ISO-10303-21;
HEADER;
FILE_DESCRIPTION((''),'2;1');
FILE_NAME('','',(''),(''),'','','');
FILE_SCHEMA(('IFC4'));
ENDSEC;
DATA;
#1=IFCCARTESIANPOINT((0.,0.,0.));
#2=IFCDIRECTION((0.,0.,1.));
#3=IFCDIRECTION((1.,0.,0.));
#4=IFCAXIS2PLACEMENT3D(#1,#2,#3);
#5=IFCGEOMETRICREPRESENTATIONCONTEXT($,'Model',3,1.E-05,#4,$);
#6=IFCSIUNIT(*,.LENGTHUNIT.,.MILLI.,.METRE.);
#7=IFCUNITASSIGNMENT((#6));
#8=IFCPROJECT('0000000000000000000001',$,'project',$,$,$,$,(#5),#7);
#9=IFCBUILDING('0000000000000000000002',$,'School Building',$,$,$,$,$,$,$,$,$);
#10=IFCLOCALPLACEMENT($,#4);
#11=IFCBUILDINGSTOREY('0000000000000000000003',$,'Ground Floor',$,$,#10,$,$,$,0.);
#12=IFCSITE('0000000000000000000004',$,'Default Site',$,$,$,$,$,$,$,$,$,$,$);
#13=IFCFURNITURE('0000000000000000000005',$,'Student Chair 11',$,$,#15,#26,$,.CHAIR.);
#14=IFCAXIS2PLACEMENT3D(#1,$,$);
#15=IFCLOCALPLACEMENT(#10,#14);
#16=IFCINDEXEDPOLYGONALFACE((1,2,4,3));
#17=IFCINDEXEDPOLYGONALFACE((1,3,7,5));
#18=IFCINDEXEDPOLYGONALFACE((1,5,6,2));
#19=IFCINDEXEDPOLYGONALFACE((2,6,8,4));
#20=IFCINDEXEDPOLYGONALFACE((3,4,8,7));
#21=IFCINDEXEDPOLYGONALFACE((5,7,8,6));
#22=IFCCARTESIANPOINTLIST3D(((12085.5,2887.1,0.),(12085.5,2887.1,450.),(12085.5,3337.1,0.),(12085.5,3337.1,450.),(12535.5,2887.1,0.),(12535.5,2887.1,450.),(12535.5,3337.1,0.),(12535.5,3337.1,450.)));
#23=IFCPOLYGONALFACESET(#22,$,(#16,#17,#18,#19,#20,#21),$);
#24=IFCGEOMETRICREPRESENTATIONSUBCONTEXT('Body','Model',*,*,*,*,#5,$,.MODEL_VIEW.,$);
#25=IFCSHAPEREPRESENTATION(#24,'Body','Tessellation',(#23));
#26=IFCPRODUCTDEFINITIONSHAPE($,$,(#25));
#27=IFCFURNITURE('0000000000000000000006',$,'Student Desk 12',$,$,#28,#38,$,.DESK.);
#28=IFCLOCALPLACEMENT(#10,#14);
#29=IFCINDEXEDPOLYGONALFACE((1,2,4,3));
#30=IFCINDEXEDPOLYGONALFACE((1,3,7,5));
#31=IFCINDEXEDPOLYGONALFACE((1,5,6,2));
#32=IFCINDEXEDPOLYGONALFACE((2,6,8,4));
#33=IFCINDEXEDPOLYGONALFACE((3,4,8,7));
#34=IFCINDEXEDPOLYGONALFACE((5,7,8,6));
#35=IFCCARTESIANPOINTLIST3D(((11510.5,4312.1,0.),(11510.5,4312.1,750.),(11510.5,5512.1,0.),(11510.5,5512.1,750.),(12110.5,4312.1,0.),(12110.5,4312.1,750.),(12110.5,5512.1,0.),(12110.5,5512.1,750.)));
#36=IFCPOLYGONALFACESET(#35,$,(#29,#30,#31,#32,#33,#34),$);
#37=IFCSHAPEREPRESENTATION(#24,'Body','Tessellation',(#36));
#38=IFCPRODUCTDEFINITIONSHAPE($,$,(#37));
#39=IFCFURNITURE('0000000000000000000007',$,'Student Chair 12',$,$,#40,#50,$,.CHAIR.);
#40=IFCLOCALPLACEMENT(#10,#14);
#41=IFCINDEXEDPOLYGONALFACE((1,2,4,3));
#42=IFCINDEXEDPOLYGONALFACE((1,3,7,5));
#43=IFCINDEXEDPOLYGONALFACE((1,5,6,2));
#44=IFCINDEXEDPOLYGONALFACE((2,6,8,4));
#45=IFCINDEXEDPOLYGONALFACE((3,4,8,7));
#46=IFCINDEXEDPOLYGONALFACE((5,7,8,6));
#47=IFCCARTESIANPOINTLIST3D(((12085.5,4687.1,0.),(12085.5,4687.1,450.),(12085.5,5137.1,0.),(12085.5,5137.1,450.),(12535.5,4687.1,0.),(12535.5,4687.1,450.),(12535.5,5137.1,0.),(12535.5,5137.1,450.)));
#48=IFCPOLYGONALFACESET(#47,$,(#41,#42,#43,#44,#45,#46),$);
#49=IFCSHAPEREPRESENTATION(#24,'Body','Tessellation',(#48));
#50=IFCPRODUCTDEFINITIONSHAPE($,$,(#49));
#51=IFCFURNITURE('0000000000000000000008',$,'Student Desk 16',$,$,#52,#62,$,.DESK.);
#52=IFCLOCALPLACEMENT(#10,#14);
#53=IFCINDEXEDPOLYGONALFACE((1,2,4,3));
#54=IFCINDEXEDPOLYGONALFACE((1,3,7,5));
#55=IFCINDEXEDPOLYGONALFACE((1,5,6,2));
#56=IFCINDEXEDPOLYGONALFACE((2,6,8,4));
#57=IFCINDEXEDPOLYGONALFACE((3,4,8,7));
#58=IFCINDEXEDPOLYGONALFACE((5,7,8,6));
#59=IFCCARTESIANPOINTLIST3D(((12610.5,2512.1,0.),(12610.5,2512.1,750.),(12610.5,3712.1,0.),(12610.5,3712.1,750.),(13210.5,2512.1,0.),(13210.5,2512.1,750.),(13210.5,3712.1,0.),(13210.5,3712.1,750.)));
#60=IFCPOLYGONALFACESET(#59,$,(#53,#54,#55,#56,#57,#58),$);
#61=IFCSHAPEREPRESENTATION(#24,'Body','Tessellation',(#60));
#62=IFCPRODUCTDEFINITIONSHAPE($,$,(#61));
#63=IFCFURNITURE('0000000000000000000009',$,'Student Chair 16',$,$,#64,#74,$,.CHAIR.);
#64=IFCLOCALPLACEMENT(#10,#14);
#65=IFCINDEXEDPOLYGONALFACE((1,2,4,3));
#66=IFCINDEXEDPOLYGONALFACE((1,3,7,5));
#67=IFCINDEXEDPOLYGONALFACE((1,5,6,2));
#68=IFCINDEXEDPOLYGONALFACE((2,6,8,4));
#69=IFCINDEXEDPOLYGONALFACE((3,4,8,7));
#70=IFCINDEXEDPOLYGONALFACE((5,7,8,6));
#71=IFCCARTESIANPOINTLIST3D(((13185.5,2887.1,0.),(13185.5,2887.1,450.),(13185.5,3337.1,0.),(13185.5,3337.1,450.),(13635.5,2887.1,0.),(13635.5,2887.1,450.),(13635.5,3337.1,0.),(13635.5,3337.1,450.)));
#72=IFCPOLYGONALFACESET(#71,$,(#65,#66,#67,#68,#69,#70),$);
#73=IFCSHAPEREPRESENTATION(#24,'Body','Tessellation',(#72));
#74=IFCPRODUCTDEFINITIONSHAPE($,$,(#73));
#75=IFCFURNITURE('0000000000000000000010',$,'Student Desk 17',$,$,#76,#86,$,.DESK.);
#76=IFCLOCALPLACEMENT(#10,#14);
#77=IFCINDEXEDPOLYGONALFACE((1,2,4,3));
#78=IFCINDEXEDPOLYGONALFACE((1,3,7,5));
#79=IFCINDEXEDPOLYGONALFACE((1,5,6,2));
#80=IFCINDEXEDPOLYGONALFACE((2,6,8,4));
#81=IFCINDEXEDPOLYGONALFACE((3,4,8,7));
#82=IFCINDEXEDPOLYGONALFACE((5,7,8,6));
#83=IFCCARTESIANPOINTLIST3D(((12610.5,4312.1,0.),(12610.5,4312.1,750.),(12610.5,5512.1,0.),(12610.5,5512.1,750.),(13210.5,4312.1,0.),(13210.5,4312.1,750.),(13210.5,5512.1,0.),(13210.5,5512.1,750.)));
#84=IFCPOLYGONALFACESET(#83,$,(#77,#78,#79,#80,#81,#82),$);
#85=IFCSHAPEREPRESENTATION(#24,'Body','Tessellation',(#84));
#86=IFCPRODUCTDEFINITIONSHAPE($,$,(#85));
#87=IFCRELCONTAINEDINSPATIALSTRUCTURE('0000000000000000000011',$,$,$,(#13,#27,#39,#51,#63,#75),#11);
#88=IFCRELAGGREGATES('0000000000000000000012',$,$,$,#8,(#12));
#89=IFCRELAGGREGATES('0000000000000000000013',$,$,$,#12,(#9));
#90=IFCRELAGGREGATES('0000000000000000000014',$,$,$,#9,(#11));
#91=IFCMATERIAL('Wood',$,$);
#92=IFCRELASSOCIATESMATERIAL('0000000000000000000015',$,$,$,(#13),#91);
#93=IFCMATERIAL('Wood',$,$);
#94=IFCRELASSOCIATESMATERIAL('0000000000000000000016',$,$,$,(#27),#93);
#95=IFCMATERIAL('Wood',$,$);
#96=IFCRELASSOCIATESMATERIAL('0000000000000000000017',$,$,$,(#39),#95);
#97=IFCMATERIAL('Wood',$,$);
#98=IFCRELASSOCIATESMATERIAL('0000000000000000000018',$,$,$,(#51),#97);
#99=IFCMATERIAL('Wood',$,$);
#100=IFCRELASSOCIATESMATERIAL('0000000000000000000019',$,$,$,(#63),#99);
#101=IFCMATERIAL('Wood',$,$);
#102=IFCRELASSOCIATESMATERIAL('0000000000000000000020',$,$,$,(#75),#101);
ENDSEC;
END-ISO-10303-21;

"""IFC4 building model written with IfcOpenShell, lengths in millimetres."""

from ifc_helpers import new_model, si_unit, frame, origin_with_axes, origin_2d, place, context, subcontext, project, spatial, rectangle, extrude, material, element, save


model = new_model("IFC4")

# Units and contexts
model_context = context("Model", 3, precision=1e-05, world=origin_with_axes())
body_context = subcontext(model_context, "Body", "Model", "MODEL_VIEW")
ifc_project = project(units=[si_unit("LENGTHUNIT", "METRE", prefix="MILLI")], contexts=[model_context])

# Site, building, storey
site = spatial("IfcSite", under=ifc_project, Name="Default Site")
building = spatial("IfcBuilding", under=site, Name="School Building")
storey_placement = place(None, origin_with_axes())
storey = spatial("IfcBuildingStorey", under=building, at=storey_placement, Name="Ground Floor", Elevation=0.0)

# Furniture
ifc_material_1 = material(Name="Wood")
furniture_1_placement = place(storey_placement, frame((12310.5, 3112.1, 0.0), z_axis=(0.0, 0.0, 1.0), x_axis=(1.0, 0.0, 0.0)))
element("IfcFurniture", 1, at=furniture_1_placement, inside=storey, material=ifc_material_1, Name="Student Chair 11", PredefinedType="CHAIR", context=body_context, shape_type="SweptSolid", body=[
    extrude(rectangle(XDim=450.0, YDim=450.0, at=origin_2d()), origin_with_axes(), (0.0, 0.0, 1.0), 450.0),
])
ifc_material_2 = material(Name="Wood")
furniture_2_placement = place(storey_placement, frame((11810.5, 4912.1, 0.0), z_axis=(0.0, 0.0, 1.0), x_axis=(0.0, 1.0, 0.0)))
element("IfcFurniture", 2, at=furniture_2_placement, inside=storey, material=ifc_material_2, Name="Student Desk 12", PredefinedType="DESK", context=body_context, shape_type="SweptSolid", body=[
    extrude(rectangle(XDim=1200.0, YDim=600.0, at=origin_2d()), origin_with_axes(), (0.0, 0.0, 1.0), 750.0),
])
ifc_material_3 = material(Name="Wood")
furniture_3_placement = place(storey_placement, frame((12310.5, 4912.1, 0.0), z_axis=(0.0, 0.0, 1.0), x_axis=(1.0, 0.0, 0.0)))
element("IfcFurniture", 3, at=furniture_3_placement, inside=storey, material=ifc_material_3, Name="Student Chair 12", PredefinedType="CHAIR", context=body_context, shape_type="SweptSolid", body=[
    extrude(rectangle(XDim=450.0, YDim=450.0, at=origin_2d()), origin_with_axes(), (0.0, 0.0, 1.0), 450.0),
])
ifc_material_4 = material(Name="Wood")
furniture_4_placement = place(storey_placement, frame((12910.5, 3112.1, 0.0), z_axis=(0.0, 0.0, 1.0), x_axis=(0.0, 1.0, 0.0)))
element("IfcFurniture", 4, at=furniture_4_placement, inside=storey, material=ifc_material_4, Name="Student Desk 16", PredefinedType="DESK", context=body_context, shape_type="SweptSolid", body=[
    extrude(rectangle(XDim=1200.0, YDim=600.0, at=origin_2d()), origin_with_axes(), (0.0, 0.0, 1.0), 750.0),
])
ifc_material_5 = material(Name="Wood")
furniture_5_placement = place(storey_placement, frame((13410.5, 3112.1, 0.0), z_axis=(0.0, 0.0, 1.0), x_axis=(1.0, 0.0, 0.0)))
element("IfcFurniture", 5, at=furniture_5_placement, inside=storey, material=ifc_material_5, Name="Student Chair 16", PredefinedType="CHAIR", context=body_context, shape_type="SweptSolid", body=[
    extrude(rectangle(XDim=450.0, YDim=450.0, at=origin_2d()), origin_with_axes(), (0.0, 0.0, 1.0), 450.0),
])
ifc_material_6 = material(Name="Wood")
furniture_6_placement = place(storey_placement, frame((12910.5, 4912.1, 0.0), z_axis=(0.0, 0.0, 1.0), x_axis=(0.0, 1.0, 0.0)))
element("IfcFurniture", 6, at=furniture_6_placement, inside=storey, material=ifc_material_6, Name="Student Desk 17", PredefinedType="DESK", context=body_context, shape_type="SweptSolid", body=[
    extrude(rectangle(XDim=1200.0, YDim=600.0, at=origin_2d()), origin_with_axes(), (0.0, 0.0, 1.0), 750.0),
])

save(model, "model.ifc")
